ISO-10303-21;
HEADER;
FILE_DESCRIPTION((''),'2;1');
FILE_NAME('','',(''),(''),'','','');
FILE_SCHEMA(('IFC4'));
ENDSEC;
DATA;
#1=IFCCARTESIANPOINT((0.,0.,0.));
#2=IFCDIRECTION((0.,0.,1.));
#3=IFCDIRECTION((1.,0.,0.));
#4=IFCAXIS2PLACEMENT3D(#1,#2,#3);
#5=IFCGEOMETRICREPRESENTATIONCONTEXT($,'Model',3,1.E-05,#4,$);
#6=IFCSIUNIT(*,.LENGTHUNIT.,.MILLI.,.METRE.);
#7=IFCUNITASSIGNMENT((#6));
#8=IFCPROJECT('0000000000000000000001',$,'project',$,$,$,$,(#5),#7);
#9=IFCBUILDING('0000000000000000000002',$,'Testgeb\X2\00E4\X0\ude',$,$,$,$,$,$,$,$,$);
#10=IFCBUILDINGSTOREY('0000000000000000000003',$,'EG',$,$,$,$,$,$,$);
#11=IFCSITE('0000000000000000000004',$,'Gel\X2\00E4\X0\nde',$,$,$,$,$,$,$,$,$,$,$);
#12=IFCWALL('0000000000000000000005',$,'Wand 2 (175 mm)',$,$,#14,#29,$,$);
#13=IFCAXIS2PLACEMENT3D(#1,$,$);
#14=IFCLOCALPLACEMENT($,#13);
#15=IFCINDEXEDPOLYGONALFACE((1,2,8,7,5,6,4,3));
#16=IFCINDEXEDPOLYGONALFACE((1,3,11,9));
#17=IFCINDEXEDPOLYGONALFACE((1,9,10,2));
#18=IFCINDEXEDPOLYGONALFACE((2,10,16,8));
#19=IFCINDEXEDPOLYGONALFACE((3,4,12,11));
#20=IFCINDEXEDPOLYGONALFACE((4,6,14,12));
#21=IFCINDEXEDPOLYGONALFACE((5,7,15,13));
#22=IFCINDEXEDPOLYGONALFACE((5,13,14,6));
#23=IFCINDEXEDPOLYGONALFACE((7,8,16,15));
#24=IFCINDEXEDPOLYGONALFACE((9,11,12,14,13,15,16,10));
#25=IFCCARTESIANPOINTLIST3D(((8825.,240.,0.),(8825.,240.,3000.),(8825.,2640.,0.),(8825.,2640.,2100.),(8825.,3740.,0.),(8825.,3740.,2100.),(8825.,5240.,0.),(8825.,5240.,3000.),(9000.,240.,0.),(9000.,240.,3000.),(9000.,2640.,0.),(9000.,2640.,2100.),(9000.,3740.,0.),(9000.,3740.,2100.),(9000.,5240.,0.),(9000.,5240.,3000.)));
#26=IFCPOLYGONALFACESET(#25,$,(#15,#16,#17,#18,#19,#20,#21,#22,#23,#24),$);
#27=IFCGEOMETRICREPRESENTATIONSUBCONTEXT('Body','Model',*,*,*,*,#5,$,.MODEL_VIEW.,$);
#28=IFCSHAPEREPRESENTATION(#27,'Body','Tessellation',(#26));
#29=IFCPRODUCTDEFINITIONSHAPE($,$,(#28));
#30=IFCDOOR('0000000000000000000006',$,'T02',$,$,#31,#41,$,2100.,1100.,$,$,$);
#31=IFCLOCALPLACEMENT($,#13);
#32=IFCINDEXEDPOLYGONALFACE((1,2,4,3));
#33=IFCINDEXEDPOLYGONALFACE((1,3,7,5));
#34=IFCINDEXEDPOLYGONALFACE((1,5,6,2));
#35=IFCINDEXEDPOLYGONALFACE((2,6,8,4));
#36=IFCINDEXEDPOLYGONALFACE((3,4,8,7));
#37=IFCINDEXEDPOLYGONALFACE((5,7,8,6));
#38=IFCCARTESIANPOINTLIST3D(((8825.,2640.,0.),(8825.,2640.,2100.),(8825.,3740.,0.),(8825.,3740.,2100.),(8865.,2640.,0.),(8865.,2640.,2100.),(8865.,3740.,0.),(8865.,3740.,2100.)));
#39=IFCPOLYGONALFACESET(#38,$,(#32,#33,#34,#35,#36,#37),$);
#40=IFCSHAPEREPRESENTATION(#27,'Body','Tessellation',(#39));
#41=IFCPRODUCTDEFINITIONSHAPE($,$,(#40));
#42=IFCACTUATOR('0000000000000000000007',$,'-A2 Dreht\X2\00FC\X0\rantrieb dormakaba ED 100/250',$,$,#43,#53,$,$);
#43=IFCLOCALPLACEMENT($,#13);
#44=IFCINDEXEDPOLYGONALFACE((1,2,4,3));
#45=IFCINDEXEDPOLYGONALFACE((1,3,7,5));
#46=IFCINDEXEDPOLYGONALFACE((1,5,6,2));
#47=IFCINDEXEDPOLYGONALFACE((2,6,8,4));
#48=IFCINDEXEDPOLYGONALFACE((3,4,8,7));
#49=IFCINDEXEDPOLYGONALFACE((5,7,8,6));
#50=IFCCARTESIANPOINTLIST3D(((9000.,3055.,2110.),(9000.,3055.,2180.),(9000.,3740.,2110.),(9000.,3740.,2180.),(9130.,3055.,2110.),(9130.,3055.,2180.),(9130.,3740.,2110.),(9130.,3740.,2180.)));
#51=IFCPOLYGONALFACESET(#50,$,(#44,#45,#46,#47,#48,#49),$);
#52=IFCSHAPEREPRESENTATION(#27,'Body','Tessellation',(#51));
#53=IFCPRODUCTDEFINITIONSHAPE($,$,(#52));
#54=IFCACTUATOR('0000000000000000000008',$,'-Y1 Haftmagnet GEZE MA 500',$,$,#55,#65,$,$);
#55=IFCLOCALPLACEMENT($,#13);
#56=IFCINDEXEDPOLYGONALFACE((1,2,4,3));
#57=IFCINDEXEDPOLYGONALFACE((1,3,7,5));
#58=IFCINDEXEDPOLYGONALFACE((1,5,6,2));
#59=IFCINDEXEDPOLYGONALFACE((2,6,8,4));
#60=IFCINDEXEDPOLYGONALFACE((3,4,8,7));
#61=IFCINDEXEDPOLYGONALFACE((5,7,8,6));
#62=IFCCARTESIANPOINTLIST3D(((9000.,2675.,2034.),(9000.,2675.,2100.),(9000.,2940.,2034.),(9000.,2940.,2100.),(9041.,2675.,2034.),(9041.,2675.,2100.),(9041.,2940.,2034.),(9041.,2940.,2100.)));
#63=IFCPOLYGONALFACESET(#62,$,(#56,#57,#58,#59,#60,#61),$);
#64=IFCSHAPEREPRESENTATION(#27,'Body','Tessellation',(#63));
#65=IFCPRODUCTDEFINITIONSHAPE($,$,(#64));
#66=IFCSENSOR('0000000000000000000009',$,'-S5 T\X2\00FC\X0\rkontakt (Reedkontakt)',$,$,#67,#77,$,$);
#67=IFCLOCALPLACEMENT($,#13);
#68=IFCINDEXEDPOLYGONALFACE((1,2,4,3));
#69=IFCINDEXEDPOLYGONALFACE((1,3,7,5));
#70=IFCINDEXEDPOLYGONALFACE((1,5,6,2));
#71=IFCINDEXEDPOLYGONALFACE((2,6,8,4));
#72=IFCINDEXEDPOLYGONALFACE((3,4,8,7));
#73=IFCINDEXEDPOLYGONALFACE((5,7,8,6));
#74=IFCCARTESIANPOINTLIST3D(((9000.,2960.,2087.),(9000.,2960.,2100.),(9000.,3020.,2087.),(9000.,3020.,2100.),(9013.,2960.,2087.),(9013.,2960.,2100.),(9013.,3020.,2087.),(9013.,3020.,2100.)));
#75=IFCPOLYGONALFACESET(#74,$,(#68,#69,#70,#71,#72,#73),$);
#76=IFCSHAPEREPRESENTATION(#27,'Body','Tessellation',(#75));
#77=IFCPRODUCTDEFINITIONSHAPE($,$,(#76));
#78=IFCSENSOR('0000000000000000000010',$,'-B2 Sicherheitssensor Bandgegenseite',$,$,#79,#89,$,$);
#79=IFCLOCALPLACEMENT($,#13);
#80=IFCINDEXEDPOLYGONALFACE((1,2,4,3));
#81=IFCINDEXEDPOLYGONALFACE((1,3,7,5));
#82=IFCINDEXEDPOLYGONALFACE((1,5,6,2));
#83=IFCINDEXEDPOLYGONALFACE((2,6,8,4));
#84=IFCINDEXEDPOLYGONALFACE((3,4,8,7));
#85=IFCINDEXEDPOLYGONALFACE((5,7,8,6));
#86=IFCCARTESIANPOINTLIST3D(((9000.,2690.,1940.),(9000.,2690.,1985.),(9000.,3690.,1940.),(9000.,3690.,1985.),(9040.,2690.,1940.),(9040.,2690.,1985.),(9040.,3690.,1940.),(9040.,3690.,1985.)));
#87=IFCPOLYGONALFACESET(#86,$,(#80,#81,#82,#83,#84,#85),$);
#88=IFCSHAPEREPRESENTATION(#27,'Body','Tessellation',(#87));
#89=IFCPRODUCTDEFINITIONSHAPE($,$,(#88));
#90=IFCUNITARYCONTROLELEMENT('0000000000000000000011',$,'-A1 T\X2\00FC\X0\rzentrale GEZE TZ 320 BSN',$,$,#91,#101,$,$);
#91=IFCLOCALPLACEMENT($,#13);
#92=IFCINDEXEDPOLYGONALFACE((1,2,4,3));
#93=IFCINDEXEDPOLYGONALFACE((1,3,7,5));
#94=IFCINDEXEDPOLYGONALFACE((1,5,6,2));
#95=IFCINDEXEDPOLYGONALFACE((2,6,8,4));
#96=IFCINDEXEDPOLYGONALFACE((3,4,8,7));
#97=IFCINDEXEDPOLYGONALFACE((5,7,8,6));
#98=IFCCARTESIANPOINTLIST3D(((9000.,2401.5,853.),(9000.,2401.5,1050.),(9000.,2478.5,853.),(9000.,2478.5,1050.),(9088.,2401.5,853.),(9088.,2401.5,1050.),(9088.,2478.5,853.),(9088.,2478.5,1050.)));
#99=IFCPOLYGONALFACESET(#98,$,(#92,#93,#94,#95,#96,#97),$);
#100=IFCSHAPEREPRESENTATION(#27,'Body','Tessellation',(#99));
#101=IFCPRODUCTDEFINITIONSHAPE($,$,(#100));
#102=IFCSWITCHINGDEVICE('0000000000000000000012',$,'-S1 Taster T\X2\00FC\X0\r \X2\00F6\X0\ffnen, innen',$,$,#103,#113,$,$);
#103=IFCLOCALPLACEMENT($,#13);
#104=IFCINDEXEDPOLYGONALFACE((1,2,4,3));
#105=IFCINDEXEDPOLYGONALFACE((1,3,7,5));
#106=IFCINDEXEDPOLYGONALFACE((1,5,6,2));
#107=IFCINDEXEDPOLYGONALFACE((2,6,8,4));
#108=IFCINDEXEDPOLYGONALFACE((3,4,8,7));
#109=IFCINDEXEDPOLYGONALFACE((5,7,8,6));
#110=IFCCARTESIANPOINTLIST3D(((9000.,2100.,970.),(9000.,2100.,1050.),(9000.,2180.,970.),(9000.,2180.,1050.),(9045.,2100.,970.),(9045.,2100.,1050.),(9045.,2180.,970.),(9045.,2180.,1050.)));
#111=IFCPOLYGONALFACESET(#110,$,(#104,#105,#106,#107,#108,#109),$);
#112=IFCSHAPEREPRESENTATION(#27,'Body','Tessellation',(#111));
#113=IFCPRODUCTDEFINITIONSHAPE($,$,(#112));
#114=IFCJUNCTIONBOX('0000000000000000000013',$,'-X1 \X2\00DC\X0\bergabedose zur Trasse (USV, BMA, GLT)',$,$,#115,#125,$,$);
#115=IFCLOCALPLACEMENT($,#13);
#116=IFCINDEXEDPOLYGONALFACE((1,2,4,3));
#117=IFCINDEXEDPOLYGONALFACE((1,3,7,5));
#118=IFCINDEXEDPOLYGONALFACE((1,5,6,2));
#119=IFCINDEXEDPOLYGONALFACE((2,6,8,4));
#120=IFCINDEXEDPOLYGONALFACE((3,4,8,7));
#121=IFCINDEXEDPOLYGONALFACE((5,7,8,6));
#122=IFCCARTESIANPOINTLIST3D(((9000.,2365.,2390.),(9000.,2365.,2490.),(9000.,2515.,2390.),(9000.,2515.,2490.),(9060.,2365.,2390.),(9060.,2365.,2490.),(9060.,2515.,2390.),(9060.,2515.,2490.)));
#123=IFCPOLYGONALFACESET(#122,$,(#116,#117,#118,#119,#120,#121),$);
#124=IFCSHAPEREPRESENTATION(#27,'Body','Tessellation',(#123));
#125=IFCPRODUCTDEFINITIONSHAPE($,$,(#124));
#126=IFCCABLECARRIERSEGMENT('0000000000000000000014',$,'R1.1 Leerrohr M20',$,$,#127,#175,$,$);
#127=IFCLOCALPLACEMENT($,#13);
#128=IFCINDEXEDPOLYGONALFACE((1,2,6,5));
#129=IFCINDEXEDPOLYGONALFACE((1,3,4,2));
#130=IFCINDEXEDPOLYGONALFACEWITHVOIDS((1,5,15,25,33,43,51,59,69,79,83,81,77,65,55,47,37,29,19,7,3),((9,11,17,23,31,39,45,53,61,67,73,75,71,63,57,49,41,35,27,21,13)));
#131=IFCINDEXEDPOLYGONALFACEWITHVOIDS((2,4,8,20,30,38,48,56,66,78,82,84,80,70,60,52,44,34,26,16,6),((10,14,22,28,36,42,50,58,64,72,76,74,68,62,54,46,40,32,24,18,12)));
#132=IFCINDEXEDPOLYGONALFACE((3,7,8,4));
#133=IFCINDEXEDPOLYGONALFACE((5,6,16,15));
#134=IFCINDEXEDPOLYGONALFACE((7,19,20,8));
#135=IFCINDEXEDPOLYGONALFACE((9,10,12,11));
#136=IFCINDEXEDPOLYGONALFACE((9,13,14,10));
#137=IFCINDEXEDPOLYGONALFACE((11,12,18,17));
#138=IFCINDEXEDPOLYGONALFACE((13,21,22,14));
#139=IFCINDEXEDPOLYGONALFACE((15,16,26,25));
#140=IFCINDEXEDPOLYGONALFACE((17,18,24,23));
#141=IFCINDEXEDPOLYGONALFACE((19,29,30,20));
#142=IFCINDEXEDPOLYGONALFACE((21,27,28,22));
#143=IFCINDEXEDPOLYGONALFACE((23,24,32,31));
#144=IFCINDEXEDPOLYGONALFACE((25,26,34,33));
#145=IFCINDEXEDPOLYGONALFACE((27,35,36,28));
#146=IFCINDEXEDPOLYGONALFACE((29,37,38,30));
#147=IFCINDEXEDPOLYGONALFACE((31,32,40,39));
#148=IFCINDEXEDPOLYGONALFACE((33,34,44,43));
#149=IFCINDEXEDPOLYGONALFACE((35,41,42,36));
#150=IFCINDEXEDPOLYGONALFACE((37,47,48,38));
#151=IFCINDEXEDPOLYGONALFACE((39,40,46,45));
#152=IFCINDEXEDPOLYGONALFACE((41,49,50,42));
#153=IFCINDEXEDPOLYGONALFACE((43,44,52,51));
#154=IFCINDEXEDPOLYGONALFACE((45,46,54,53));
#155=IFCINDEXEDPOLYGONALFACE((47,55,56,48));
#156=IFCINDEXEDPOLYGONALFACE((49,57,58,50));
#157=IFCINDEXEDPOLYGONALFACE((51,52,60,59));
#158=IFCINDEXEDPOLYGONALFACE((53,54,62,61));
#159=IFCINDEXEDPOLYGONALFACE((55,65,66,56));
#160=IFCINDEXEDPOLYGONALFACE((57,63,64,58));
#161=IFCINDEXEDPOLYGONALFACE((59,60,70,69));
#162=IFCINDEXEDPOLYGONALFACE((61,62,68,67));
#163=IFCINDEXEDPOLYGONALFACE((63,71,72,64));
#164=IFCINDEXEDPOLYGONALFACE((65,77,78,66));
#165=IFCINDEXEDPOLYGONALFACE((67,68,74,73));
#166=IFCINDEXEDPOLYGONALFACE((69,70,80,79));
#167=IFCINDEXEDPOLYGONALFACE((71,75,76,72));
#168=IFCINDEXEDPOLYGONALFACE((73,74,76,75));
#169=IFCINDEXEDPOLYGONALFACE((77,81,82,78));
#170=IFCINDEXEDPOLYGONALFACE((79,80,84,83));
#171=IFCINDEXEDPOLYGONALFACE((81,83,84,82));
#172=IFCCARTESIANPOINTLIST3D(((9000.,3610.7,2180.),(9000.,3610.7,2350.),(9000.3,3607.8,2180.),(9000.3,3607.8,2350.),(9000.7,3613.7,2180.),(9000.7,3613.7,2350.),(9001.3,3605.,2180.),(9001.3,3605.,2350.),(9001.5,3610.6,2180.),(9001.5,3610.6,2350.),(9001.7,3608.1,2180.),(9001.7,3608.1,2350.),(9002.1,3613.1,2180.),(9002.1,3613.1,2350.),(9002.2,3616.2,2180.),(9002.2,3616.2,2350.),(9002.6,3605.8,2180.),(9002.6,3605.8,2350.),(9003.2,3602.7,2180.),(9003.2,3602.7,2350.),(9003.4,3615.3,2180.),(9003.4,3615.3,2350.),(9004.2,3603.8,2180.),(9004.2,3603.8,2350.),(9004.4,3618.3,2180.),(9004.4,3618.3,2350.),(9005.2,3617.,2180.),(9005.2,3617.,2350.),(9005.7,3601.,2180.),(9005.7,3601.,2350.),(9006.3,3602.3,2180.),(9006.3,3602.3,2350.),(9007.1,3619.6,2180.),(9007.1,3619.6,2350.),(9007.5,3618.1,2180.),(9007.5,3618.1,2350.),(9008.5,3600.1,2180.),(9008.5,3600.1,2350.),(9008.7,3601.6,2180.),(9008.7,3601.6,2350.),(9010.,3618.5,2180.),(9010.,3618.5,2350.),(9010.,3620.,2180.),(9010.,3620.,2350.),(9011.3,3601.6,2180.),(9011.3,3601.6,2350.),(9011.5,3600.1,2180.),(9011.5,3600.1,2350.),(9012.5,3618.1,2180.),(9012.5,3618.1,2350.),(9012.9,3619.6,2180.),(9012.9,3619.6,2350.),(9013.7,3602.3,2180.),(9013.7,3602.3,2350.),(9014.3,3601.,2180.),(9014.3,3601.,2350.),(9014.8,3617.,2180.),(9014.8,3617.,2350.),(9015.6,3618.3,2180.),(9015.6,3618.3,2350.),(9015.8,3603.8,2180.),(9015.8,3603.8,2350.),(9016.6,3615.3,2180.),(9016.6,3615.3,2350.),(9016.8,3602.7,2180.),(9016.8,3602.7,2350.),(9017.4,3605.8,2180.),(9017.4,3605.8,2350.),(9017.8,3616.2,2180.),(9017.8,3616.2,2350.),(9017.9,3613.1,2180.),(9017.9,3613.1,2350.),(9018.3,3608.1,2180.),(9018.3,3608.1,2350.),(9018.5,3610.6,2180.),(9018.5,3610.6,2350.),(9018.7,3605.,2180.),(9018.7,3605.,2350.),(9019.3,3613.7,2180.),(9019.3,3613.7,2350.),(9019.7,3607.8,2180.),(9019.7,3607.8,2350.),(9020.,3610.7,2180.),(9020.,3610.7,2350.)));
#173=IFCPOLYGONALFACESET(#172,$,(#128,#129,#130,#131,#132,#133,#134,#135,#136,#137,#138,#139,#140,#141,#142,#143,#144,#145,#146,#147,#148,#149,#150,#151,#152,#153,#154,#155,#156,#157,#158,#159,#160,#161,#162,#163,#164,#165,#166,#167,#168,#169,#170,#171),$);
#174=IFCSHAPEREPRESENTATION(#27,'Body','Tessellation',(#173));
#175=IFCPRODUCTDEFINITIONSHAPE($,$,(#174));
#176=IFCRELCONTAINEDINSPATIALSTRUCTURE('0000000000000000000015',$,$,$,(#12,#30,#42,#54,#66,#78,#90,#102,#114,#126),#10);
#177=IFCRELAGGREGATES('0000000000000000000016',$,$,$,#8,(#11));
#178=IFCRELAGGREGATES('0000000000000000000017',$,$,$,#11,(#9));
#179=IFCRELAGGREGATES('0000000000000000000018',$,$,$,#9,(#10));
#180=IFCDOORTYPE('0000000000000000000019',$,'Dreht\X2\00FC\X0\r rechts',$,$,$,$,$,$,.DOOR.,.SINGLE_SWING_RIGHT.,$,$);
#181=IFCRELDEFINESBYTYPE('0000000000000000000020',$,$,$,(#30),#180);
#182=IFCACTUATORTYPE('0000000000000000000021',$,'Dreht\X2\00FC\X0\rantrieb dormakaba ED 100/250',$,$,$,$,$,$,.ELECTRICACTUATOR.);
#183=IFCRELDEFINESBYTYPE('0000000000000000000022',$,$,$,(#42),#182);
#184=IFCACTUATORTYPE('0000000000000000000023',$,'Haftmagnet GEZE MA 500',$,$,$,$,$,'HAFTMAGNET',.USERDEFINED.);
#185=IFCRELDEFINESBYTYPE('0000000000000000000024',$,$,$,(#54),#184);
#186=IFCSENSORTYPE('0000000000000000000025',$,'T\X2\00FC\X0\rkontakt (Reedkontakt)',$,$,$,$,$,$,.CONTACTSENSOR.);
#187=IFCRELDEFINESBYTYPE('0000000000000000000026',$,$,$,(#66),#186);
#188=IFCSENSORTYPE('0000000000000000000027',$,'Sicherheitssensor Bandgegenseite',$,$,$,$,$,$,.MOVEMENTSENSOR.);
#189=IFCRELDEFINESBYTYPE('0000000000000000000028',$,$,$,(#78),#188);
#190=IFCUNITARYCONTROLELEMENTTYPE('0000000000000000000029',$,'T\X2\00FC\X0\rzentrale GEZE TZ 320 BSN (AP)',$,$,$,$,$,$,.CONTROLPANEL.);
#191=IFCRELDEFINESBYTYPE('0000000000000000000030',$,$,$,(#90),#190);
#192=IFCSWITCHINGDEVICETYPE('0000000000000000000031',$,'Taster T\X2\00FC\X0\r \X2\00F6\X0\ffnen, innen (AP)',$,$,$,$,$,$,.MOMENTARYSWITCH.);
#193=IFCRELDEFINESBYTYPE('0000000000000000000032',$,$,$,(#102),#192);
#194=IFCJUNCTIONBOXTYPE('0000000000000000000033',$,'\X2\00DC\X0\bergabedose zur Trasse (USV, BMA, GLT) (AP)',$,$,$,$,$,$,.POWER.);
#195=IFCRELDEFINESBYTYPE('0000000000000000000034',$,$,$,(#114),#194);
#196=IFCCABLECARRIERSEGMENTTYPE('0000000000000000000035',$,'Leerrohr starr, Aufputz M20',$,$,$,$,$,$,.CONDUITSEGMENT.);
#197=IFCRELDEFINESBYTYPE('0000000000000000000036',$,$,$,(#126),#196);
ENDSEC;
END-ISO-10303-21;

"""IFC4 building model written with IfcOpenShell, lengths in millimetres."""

from ifc_helpers import new_model, si_unit, frame, frame_2d, origin_with_axes, place, context, subcontext, project, spatial, rectangle, hollow_circle, extrude, type_object, element, fill, save


model = new_model("IFC4")

# Units and contexts
model_context = context("Model", 3, precision=1e-05, world=origin_with_axes())
body_context = subcontext(model_context, "Body", "Model", "MODEL_VIEW")
ifc_project = project(units=[si_unit("LENGTHUNIT", "METRE", prefix="MILLI")], contexts=[model_context])

# Site, building, storey
site = spatial("IfcSite", under=ifc_project, Name="Gelände")
building = spatial("IfcBuilding", under=site, Name="Testgebäude")
storey = spatial("IfcBuildingStorey", under=building, Name="EG")

# Wall, opening, door
wall_placement = place(None, frame((9000.0, 240.0, 0.0), z_axis=(0.0, 0.0, 1.0), x_axis=(0.0, 1.0, 0.0)))
wall = element("IfcWall", 1, at=wall_placement, inside=storey, Name="Wand 2 (175 mm)", context=body_context, shape_type="SweptSolid", body=[
    extrude(rectangle(XDim=5000.0, YDim=175.0, at=frame_2d((2500.0, 87.5))), None, (0.0, 0.0, 1.0), 3000.0),
])
opening_placement = place(None, frame((9000.0, 2640.0, 0.0), z_axis=(0.0, 0.0, 1.0), x_axis=(0.0, 1.0, 0.0)))
opening = element("IfcOpeningElement", 2, at=opening_placement, cuts=wall, context=body_context, shape_type="SweptSolid", body=[
    extrude(rectangle(XDim=1100.0, YDim=175.0, at=frame_2d((550.0, 87.5))), None, (0.0, 0.0, 1.0), 2100.0),
])
door_type = type_object("IfcDoorType", Name="Drehtür rechts", OperationType="SINGLE_SWING_RIGHT", PredefinedType="DOOR")
door_placement = place(opening_placement, origin_with_axes())
door = element("IfcDoor", 3, at=door_placement, inside=storey, type_object=door_type, Name="T02", OverallHeight=2100.0, OverallWidth=1100.0, context=body_context, shape_type="SweptSolid", body=[
    extrude(rectangle(XDim=1100.0, YDim=40.0, at=frame_2d((550.0, 20.0))), frame((0.0, 135.0, 0.0)), (0.0, 0.0, 1.0), 2100.0),
])
fill(opening, door)

# Actuators
actuator_type_1 = type_object("IfcActuatorType", Name="Drehtürantrieb dormakaba ED 100/250", PredefinedType="ELECTRICACTUATOR")
actuator_1_placement = place(None, frame((9130.0, 3055.0, 2110.0), z_axis=(0.0, 0.0, 1.0), x_axis=(0.0, 1.0, 0.0)))
element("IfcActuator", 4, at=actuator_1_placement, inside=storey, type_object=actuator_type_1, Name="-A2 Drehtürantrieb dormakaba ED 100/250", context=body_context, shape_type="SweptSolid", body=[
    extrude(rectangle(XDim=685.0, YDim=130.0, at=frame_2d((342.5, 65.0))), None, (0.0, 0.0, 1.0), 70.0),
])
actuator_type_2 = type_object("IfcActuatorType", Name="Haftmagnet GEZE MA 500", ElementType="HAFTMAGNET", PredefinedType="USERDEFINED")
actuator_2_placement = place(None, frame((9041.0, 2675.0, 2034.0), z_axis=(0.0, 0.0, 1.0), x_axis=(0.0, 1.0, 0.0)))
element("IfcActuator", 5, at=actuator_2_placement, inside=storey, type_object=actuator_type_2, Name="-Y1 Haftmagnet GEZE MA 500", context=body_context, shape_type="SweptSolid", body=[
    extrude(rectangle(XDim=265.0, YDim=41.0, at=frame_2d((132.5, 20.5))), None, (0.0, 0.0, 1.0), 66.0),
])

# Sensors
sensor_type_1 = type_object("IfcSensorType", Name="Türkontakt (Reedkontakt)", PredefinedType="CONTACTSENSOR")
sensor_1_placement = place(None, frame((9013.0, 2960.0, 2087.0), z_axis=(0.0, 0.0, 1.0), x_axis=(0.0, 1.0, 0.0)))
element("IfcSensor", 6, at=sensor_1_placement, inside=storey, type_object=sensor_type_1, Name="-S5 Türkontakt (Reedkontakt)", context=body_context, shape_type="SweptSolid", body=[
    extrude(rectangle(XDim=60.0, YDim=13.0, at=frame_2d((30.0, 6.5))), None, (0.0, 0.0, 1.0), 13.0),
])
sensor_type_2 = type_object("IfcSensorType", Name="Sicherheitssensor Bandgegenseite", PredefinedType="MOVEMENTSENSOR")
sensor_2_placement = place(None, frame((9040.0, 2690.0, 1940.0), z_axis=(0.0, 0.0, 1.0), x_axis=(0.0, 1.0, 0.0)))
element("IfcSensor", 7, at=sensor_2_placement, inside=storey, type_object=sensor_type_2, Name="-B2 Sicherheitssensor Bandgegenseite", context=body_context, shape_type="SweptSolid", body=[
    extrude(rectangle(XDim=1000.0, YDim=40.0, at=frame_2d((500.0, 20.0))), None, (0.0, 0.0, 1.0), 45.0),
])

# Unitary control element
unitary_control_element_type = type_object("IfcUnitaryControlElementType", Name="Türzentrale GEZE TZ 320 BSN (AP)", PredefinedType="CONTROLPANEL")
unitary_control_element_placement = place(None, frame((9088.0, 2401.5, 853.0), z_axis=(0.0, 0.0, 1.0), x_axis=(0.0, 1.0, 0.0)))
element("IfcUnitaryControlElement", 8, at=unitary_control_element_placement, inside=storey, type_object=unitary_control_element_type, Name="-A1 Türzentrale GEZE TZ 320 BSN", context=body_context, shape_type="SweptSolid", body=[
    extrude(rectangle(XDim=77.0, YDim=88.0, at=frame_2d((38.5, 44.0))), None, (0.0, 0.0, 1.0), 197.0),
])

# Switching device
switching_device_type = type_object("IfcSwitchingDeviceType", Name="Taster Tür öffnen, innen (AP)", PredefinedType="MOMENTARYSWITCH")
switching_device_placement = place(None, frame((9045.0, 2100.0, 970.0), z_axis=(0.0, 0.0, 1.0), x_axis=(0.0, 1.0, 0.0)))
element("IfcSwitchingDevice", 9, at=switching_device_placement, inside=storey, type_object=switching_device_type, Name="-S1 Taster Tür öffnen, innen", context=body_context, shape_type="SweptSolid", body=[
    extrude(rectangle(XDim=80.0, YDim=45.0, at=frame_2d((40.0, 22.5))), None, (0.0, 0.0, 1.0), 80.0),
])

# Junction box
junction_box_type = type_object("IfcJunctionBoxType", Name="Übergabedose zur Trasse (USV, BMA, GLT) (AP)", PredefinedType="POWER")
junction_box_placement = place(None, frame((9060.0, 2365.0, 2390.0), z_axis=(0.0, 0.0, 1.0), x_axis=(0.0, 1.0, 0.0)))
element("IfcJunctionBox", 10, at=junction_box_placement, inside=storey, type_object=junction_box_type, Name="-X1 Übergabedose zur Trasse (USV, BMA, GLT)", context=body_context, shape_type="SweptSolid", body=[
    extrude(rectangle(XDim=150.0, YDim=60.0, at=frame_2d((75.0, 30.0))), None, (0.0, 0.0, 1.0), 100.0),
])

# Cable carrier segment
cable_carrier_segment_type_1 = type_object("IfcCableCarrierSegmentType", Name="Leerrohr starr, Aufputz M20", PredefinedType="CONDUITSEGMENT")
cable_carrier_segment_1_placement = place(None, frame((9010.0, 3610.0, 2180.0), z_axis=(0.0, 0.0, 1.0), x_axis=(0.0, 1.0, 0.0)))
element("IfcCableCarrierSegment", 11, at=cable_carrier_segment_1_placement, inside=storey, type_object=cable_carrier_segment_type_1, Name="R1.1 Leerrohr M20", context=body_context, shape_type="SweptSolid", body=[
    extrude(hollow_circle(Radius=10.0, WallThickness=1.5), None, (0.0, 0.0, 1.0), 170.0),
])

save(model, "model.ifc")
